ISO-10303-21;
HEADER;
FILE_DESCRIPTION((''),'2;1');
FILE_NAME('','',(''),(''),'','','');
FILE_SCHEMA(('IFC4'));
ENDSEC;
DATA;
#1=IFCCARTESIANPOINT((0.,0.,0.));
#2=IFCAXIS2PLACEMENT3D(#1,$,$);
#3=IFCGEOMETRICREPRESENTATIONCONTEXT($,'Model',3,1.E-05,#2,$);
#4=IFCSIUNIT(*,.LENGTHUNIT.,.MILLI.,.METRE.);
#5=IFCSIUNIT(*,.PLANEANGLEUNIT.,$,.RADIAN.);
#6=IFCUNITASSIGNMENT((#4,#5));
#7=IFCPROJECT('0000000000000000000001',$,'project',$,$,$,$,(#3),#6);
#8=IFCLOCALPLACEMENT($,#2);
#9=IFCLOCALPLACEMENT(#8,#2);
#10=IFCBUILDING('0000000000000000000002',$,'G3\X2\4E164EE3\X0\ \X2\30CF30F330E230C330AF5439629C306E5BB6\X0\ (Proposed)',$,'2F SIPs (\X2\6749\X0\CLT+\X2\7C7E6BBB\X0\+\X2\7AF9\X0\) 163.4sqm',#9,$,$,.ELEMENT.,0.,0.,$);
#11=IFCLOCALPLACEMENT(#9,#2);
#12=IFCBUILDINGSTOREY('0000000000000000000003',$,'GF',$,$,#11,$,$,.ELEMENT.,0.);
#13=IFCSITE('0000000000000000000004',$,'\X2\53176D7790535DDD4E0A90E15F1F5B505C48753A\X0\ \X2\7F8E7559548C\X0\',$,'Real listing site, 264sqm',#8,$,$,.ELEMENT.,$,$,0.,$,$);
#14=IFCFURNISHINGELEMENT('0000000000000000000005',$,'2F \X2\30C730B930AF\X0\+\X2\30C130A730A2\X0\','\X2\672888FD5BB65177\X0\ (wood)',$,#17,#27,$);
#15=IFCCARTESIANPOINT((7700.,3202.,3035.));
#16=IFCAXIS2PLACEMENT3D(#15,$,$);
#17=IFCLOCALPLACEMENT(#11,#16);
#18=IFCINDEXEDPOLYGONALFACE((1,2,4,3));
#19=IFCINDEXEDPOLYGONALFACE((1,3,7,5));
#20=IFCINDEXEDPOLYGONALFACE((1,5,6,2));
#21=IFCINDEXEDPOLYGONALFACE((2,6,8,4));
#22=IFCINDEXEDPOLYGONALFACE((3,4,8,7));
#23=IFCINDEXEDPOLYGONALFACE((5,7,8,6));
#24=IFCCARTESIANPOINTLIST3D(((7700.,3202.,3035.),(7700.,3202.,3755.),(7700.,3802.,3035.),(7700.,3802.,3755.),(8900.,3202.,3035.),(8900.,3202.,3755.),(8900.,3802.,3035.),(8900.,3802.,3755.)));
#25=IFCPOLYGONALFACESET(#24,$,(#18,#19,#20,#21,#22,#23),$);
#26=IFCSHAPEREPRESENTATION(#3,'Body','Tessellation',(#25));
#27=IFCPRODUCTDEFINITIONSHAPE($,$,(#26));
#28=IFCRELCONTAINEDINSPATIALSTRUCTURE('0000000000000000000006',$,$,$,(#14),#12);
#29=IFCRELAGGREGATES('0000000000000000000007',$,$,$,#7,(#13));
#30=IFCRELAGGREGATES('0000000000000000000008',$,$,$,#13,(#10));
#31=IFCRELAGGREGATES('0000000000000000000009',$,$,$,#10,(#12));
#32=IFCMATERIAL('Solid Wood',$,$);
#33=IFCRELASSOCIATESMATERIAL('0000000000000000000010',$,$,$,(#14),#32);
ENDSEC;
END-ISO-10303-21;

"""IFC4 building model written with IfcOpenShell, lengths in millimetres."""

from ifc_helpers import new_model, si_unit, frame, frame_2d, origin, place, context, project, spatial, rectangle, extrude, material, element, save


model = new_model("IFC4")

# Units and contexts
model_context = context("Model", 3, precision=1e-05, world=origin())
ifc_project = project(units=[si_unit("LENGTHUNIT", "METRE", prefix="MILLI"), si_unit("PLANEANGLEUNIT", "RADIAN")], contexts=[model_context])

# Site, building, storey
site_placement = place(None, origin())
site = spatial("IfcSite", under=ifc_project, at=site_placement, Name="北海道川上郡弟子屈町 美留和", ObjectType="Real listing site, 264sqm", CompositionType="ELEMENT", RefElevation=0.0)
building_placement = place(site_placement, origin())
building = spatial("IfcBuilding", under=site, at=building_placement, Name="G3世代 ハンモック吹抜の家 (Proposed)", ObjectType="2F SIPs (杉CLT+籾殻+竹) 163.4sqm", CompositionType="ELEMENT", ElevationOfRefHeight=0.0, ElevationOfTerrain=0.0)
storey_placement = place(building_placement, origin())
storey = spatial("IfcBuildingStorey", under=building, at=storey_placement, Name="GF", CompositionType="ELEMENT", Elevation=0.0)

# Shared definitions
ifc_material_1 = material(Name="Solid Wood")

# Furnishing element
furnishing_1_placement = place(storey_placement, frame((7700.0, 3202.0, 3035.0)))
element("IfcFurnishingElement", 1, at=furnishing_1_placement, inside=storey, material=ifc_material_1, Name="2F デスク+チェア", Description="木製家具 (wood)", context=model_context, shape_type="SweptSolid", body=[
    extrude(rectangle(XDim=1200.0, YDim=600.0, at=frame_2d((600.0, 300.0))), frame((7700.0, 3202.0, 3035.0)), (0.0, 0.0, 1.0), 720.0),
])

save(model, "model.ifc")
